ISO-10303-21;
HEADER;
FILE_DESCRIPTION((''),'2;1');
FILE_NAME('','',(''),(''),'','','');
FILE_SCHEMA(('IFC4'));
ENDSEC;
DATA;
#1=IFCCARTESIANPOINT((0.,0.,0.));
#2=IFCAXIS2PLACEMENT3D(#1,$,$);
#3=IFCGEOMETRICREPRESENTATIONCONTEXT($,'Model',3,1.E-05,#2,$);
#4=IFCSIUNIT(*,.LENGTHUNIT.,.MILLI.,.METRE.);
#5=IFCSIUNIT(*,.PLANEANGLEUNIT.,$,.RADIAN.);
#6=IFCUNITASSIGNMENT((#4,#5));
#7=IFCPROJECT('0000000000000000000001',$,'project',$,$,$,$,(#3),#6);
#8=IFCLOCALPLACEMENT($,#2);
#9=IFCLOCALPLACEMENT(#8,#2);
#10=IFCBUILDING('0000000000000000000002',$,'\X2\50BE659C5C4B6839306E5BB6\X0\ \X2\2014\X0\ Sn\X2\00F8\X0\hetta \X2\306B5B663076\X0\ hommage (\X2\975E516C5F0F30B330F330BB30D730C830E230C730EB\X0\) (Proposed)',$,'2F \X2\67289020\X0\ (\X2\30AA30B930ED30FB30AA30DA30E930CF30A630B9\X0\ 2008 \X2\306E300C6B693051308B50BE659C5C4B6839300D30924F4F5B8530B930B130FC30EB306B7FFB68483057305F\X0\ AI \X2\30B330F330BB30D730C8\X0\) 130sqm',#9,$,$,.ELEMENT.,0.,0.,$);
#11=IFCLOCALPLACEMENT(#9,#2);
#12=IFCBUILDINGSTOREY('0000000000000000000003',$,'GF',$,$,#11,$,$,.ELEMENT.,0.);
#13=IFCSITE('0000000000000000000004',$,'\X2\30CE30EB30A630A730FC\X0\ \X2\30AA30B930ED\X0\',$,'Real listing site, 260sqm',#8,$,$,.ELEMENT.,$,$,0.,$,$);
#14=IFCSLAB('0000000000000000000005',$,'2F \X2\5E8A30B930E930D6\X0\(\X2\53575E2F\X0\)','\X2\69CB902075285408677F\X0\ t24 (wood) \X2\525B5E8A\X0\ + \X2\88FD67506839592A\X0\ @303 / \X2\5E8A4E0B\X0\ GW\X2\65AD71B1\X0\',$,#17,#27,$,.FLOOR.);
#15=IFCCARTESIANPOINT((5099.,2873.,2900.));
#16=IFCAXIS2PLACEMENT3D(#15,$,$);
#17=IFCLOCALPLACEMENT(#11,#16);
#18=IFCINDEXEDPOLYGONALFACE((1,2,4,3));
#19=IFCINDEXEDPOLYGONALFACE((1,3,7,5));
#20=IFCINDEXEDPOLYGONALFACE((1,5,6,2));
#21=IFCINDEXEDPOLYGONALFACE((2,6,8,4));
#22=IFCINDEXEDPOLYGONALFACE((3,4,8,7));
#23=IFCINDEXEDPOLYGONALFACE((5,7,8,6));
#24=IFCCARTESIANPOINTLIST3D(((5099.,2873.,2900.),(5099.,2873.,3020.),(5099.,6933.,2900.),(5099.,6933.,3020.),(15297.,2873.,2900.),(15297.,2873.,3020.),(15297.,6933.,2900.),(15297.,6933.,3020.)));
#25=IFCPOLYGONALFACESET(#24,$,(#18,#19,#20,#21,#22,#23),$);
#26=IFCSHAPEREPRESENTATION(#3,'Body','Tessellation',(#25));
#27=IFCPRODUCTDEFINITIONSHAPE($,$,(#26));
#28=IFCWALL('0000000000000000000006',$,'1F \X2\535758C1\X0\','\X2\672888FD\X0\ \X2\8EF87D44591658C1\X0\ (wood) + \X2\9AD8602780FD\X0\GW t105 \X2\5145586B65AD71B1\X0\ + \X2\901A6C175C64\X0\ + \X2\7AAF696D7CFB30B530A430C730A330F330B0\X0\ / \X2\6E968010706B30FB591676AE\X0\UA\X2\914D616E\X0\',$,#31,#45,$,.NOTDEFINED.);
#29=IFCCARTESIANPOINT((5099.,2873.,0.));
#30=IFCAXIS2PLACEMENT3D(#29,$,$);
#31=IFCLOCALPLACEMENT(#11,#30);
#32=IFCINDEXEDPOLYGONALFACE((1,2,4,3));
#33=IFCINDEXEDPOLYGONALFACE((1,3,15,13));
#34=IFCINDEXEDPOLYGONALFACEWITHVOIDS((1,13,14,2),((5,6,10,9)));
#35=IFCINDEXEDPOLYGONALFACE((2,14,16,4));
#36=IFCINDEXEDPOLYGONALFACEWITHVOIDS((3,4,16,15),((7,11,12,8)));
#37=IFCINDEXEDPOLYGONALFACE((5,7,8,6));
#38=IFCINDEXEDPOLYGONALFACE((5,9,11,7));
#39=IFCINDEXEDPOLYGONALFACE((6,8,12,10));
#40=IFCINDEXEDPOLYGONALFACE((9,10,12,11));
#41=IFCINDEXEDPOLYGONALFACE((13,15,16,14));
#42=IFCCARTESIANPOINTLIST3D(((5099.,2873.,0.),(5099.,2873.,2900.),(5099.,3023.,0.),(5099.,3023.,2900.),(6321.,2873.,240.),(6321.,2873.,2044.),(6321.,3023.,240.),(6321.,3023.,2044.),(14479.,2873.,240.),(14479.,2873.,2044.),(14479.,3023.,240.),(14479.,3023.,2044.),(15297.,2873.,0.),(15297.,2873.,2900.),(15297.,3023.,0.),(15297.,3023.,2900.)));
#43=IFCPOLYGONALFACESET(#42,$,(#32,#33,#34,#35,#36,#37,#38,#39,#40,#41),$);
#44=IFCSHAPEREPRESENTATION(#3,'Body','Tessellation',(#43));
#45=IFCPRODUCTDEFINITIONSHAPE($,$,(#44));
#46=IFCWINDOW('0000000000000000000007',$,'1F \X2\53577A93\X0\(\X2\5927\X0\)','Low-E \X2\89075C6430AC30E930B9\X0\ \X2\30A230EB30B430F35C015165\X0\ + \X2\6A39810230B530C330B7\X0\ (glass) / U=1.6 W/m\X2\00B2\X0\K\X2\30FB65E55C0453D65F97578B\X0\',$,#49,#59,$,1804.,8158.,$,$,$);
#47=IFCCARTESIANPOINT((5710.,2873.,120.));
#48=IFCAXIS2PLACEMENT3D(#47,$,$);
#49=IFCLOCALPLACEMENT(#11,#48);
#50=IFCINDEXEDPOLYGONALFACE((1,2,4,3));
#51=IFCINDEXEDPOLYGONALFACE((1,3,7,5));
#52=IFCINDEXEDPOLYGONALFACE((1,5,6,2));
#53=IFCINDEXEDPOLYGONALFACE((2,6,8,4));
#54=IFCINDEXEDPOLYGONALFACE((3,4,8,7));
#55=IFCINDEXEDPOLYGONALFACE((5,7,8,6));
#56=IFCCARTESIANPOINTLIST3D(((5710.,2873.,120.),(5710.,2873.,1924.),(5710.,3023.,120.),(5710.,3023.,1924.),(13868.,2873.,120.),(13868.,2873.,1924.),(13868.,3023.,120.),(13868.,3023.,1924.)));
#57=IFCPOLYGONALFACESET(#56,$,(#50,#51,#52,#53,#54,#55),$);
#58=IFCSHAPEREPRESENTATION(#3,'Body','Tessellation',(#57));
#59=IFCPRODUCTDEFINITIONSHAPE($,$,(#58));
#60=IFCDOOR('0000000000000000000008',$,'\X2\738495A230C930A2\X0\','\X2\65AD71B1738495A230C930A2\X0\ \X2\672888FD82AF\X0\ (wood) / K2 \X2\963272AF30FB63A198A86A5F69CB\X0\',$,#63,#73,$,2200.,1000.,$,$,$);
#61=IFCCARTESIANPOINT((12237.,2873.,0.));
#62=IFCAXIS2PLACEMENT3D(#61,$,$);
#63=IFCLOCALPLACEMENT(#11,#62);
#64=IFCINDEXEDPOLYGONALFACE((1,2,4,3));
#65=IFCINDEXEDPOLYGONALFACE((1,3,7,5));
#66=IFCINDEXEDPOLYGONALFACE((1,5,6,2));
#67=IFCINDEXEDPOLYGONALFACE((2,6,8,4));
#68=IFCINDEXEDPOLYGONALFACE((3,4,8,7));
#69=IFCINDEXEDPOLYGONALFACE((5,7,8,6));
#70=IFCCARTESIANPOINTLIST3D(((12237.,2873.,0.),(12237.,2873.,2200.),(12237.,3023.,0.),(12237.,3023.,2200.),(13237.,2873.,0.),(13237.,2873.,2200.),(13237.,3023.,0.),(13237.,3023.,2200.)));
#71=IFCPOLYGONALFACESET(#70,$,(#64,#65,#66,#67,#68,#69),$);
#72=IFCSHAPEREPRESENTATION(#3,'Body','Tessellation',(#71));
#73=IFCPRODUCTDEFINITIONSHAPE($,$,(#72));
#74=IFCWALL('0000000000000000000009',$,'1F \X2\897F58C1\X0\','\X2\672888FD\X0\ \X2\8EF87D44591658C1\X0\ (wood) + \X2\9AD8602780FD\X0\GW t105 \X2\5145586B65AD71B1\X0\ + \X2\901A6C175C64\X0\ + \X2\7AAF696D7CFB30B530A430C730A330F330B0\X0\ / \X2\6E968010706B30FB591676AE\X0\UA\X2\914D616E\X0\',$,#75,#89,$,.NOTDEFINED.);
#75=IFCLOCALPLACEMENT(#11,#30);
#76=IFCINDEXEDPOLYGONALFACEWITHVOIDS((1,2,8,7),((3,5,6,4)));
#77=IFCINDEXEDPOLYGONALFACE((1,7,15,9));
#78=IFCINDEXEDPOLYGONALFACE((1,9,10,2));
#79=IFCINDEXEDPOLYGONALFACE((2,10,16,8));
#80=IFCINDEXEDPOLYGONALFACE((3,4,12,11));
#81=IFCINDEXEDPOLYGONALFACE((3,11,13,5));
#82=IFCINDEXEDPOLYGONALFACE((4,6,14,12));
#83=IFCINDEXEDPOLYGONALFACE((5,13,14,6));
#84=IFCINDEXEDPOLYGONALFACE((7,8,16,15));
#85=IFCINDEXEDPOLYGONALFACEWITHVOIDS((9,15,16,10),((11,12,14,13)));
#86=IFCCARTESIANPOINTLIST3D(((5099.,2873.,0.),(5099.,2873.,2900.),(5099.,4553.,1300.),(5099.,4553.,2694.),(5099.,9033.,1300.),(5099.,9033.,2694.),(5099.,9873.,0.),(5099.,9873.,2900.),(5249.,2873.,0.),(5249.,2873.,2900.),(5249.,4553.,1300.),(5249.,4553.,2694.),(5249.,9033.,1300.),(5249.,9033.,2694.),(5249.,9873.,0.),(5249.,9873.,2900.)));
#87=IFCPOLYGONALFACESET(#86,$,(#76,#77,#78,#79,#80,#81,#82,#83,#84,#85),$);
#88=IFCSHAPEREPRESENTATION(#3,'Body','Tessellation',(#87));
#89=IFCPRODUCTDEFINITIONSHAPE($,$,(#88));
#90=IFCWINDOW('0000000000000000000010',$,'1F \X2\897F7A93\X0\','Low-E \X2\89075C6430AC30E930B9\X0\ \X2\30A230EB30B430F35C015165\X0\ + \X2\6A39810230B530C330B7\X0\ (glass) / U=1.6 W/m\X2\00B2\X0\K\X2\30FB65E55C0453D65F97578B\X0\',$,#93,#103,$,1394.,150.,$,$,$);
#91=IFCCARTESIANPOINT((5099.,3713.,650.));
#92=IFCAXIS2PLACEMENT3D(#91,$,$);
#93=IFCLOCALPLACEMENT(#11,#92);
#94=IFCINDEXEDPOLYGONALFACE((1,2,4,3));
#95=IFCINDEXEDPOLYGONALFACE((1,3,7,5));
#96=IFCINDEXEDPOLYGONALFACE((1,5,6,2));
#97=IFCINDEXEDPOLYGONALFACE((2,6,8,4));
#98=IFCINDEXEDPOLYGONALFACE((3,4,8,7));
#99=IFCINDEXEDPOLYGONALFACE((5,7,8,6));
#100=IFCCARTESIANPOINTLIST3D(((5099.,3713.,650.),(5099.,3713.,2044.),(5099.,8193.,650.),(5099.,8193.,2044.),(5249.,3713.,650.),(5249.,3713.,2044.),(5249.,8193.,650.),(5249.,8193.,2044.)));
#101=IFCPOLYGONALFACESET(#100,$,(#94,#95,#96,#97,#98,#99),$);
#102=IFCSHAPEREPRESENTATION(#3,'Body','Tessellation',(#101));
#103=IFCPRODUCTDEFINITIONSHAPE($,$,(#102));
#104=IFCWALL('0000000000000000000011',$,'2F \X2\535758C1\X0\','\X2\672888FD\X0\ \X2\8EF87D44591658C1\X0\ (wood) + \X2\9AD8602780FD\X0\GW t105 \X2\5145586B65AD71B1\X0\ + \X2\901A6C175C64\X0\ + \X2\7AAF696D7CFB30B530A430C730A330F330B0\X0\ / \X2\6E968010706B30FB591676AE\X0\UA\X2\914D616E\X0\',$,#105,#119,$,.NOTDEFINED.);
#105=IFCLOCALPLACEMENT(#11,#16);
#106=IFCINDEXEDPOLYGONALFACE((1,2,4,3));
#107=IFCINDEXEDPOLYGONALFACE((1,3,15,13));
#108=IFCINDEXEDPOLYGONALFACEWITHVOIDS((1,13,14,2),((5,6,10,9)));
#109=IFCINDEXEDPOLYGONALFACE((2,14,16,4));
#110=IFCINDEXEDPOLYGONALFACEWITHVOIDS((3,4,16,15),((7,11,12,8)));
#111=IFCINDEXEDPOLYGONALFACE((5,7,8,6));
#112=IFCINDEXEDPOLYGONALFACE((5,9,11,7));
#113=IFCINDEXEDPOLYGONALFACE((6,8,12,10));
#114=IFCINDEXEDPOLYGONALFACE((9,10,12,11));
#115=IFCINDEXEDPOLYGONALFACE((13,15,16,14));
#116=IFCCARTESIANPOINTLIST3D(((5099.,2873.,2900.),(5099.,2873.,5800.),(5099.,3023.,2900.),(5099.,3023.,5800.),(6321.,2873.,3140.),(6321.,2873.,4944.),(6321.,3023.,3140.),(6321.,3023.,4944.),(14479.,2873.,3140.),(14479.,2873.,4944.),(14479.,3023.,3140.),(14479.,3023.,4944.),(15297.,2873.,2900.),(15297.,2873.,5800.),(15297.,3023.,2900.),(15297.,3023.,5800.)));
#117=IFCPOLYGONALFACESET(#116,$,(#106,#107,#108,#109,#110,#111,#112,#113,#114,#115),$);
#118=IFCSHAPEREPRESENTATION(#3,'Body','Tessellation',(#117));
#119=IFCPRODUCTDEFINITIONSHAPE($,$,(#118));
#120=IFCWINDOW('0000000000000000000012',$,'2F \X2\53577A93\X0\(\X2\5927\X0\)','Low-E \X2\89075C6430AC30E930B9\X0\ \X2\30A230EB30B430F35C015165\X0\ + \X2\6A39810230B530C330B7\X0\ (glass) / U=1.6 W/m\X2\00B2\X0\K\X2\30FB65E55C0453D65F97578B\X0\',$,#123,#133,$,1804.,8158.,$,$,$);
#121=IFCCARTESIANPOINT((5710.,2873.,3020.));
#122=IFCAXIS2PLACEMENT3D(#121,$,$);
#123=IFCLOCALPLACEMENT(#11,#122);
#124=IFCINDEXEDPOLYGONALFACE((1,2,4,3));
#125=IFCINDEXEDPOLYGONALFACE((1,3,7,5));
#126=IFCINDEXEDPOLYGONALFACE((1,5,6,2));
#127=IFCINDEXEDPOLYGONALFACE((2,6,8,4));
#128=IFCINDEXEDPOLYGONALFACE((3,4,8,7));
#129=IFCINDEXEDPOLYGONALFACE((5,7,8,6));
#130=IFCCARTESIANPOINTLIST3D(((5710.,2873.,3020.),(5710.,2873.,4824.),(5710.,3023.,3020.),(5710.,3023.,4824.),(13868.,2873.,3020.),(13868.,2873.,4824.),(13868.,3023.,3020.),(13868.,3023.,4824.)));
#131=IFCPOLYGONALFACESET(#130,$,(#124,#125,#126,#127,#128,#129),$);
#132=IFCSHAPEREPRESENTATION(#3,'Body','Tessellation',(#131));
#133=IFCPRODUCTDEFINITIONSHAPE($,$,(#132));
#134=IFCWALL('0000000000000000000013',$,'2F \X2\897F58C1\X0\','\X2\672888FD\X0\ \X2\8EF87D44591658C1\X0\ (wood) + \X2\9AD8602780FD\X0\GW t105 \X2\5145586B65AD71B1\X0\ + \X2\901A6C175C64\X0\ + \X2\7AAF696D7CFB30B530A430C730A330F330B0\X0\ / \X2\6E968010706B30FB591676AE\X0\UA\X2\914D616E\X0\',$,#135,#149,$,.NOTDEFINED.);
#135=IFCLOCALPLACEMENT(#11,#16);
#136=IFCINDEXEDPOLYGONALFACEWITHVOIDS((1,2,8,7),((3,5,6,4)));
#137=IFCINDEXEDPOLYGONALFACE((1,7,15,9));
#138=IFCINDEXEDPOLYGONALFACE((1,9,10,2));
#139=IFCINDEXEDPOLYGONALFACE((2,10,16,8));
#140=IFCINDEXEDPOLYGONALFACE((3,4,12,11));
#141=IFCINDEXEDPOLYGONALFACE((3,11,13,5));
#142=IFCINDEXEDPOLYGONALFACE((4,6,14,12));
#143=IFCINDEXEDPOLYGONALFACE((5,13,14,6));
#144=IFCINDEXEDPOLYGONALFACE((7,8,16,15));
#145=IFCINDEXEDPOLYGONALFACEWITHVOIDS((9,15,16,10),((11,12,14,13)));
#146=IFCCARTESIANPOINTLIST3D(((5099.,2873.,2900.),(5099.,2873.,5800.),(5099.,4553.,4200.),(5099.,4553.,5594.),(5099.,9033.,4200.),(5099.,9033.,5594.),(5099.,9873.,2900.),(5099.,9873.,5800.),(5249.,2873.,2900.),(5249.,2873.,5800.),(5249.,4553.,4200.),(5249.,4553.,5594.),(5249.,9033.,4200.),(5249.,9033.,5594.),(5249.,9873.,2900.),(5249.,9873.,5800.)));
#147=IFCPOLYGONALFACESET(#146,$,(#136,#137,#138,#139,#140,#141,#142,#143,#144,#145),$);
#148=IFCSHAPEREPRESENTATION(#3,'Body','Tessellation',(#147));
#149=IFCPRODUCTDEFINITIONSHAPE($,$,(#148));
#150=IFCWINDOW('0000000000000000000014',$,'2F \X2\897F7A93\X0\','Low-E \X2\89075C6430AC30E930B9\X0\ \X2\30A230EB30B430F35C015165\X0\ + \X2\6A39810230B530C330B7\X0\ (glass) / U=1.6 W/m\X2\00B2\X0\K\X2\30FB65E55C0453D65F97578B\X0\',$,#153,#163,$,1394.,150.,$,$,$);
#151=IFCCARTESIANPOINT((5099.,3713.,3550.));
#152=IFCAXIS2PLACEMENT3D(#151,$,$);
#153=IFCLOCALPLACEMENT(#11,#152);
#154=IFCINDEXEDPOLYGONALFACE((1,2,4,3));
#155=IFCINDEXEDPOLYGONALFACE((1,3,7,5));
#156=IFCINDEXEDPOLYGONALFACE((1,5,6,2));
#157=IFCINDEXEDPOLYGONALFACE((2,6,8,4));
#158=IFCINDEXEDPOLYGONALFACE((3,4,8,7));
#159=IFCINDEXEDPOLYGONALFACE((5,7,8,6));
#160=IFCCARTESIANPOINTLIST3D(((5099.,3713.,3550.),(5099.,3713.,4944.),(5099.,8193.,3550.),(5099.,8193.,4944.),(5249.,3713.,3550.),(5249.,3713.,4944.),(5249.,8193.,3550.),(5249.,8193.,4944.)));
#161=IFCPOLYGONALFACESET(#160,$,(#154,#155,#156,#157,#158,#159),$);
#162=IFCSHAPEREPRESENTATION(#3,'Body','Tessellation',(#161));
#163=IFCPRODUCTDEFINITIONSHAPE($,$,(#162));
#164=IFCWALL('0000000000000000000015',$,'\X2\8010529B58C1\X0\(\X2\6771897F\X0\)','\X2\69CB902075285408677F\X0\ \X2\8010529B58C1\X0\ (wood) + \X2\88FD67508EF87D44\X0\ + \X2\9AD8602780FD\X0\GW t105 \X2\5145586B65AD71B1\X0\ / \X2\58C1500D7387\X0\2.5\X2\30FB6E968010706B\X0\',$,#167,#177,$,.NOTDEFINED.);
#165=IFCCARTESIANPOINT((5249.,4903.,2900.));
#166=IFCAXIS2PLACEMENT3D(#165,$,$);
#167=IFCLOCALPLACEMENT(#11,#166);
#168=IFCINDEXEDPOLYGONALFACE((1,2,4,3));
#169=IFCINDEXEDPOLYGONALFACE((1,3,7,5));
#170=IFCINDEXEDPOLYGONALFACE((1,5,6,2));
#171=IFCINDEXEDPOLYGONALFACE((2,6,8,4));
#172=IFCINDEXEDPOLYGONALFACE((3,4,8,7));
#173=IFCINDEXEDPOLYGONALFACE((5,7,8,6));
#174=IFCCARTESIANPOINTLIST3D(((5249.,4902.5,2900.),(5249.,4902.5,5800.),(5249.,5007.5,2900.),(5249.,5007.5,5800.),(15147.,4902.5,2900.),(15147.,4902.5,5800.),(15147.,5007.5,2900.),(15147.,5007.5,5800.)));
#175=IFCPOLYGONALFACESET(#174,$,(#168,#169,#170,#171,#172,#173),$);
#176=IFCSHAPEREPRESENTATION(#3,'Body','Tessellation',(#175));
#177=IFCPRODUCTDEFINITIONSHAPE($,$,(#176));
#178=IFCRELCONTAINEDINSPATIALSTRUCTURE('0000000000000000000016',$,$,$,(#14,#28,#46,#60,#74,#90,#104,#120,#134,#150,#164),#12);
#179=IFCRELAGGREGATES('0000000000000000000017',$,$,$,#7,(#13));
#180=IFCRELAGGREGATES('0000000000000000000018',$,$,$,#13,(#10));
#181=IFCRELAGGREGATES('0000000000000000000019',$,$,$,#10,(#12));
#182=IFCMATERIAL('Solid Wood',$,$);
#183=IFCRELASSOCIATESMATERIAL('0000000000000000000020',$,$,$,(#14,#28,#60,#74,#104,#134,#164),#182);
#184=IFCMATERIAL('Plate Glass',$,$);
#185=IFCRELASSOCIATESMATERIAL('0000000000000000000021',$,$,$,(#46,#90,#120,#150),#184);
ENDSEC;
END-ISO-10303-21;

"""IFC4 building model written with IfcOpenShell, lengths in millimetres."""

from ifc_helpers import new_model, si_unit, frame, frame_2d, origin, place, context, project, spatial, rectangle, extrude, material, element, fill, save


model = new_model("IFC4")

# Units and contexts
model_context = context("Model", 3, precision=1e-05, world=origin())
ifc_project = project(units=[si_unit("LENGTHUNIT", "METRE", prefix="MILLI"), si_unit("PLANEANGLEUNIT", "RADIAN")], contexts=[model_context])

# Site, building, storey
site_placement = place(None, origin())
site = spatial("IfcSite", under=ifc_project, at=site_placement, Name="ノルウェー オスロ", ObjectType="Real listing site, 260sqm", CompositionType="ELEMENT", RefElevation=0.0)
building_placement = place(site_placement, origin())
building = spatial("IfcBuilding", under=site, at=building_placement, Name="傾斜屋根の家 — Snøhetta に学ぶ hommage (非公式コンセプトモデル) (Proposed)", ObjectType="2F 木造 (オスロ・オペラハウス 2008 の「歩ける傾斜屋根」を住宅スケールに翻案した AI コンセプト) 130sqm", CompositionType="ELEMENT", ElevationOfRefHeight=0.0, ElevationOfTerrain=0.0)
storey_placement = place(building_placement, origin())
storey = spatial("IfcBuildingStorey", under=building, at=storey_placement, Name="GF", CompositionType="ELEMENT", Elevation=0.0)

# Slab
ifc_material_1 = material(Name="Solid Wood")
slab_1_placement = place(storey_placement, frame((5099.0, 2873.0, 2900.0)))
element("IfcSlab", 1, at=slab_1_placement, inside=storey, material=ifc_material_1, Name="2F 床スラブ(南帯)", Description="構造用合板 t24 (wood) 剛床 + 製材根太 @303 / 床下 GW断熱", PredefinedType="FLOOR", context=model_context, shape_type="SweptSolid", body=[
    extrude(rectangle(XDim=10198.0, YDim=4060.0, at=frame_2d((5099.0, 2030.0))), frame((5099.0, 2873.0, 2900.0)), (0.0, 0.0, 1.0), 120.0),
])

# Wall, openings, window, door
wall_1_placement = place(storey_placement, frame((5099.0, 2873.0, 0.0)))
wall_1 = element("IfcWall", 2, at=wall_1_placement, inside=storey, material=ifc_material_1, Name="1F 南壁", Description="木製 軸組外壁 (wood) + 高性能GW t105 充填断熱 + 通気層 + 窯業系サイディング / 準耐火・外皮UA配慮", PredefinedType="NOTDEFINED", context=model_context, shape_type="SweptSolid", body=[
    extrude(rectangle(XDim=10198.0, YDim=150.0, at=frame_2d((5099.0, 75.0))), frame((5099.0, 2873.0, 0.0)), (0.0, 0.0, 1.0), 2900.0),
])
opening_1_placement = place(storey_placement, frame((5710.0, 2873.0, 120.0)))
opening_1 = element("IfcOpeningElement", 3, at=opening_1_placement, cuts=wall_1, PredefinedType="NOTDEFINED", context=model_context, shape_type="SweptSolid", body=[
    extrude(rectangle(XDim=8158.0, YDim=150.0, at=frame_2d((4079.0, 75.0))), frame((5710.0, 2873.0, 120.0)), (0.0, 0.0, 1.0), 1804.0),
])
opening_2_placement = place(storey_placement, frame((12237.0, 2873.0, 0.0)))
opening_2 = element("IfcOpeningElement", 4, at=opening_2_placement, cuts=wall_1, PredefinedType="NOTDEFINED", context=model_context, shape_type="SweptSolid", body=[
    extrude(rectangle(XDim=1000.0, YDim=150.0, at=frame_2d((500.0, 75.0))), frame((12237.0, 2873.0, 0.0)), (0.0, 0.0, 1.0), 2200.0),
])
ifc_material_2 = material(Name="Plate Glass")
window_1_placement = place(storey_placement, frame((5710.0, 2873.0, 120.0)))
window_1 = element("IfcWindow", 5, at=window_1_placement, inside=storey, material=ifc_material_2, Name="1F 南窓(大)", Description="Low-E 複層ガラス アルゴン封入 + 樹脂サッシ (glass) / U=1.6 W/m²K・日射取得型", OverallHeight=1804.0, OverallWidth=8158.0, context=model_context, shape_type="SweptSolid", body=[
    extrude(rectangle(XDim=8158.0, YDim=150.0, at=frame_2d((4079.0, 75.0))), frame((5710.0, 2873.0, 120.0)), (0.0, 0.0, 1.0), 1804.0),
])
fill(opening_1, window_1)
door_placement = place(storey_placement, frame((12237.0, 2873.0, 0.0)))
door = element("IfcDoor", 6, at=door_placement, inside=storey, material=ifc_material_1, Name="玄関ドア", Description="断熱玄関ドア 木製芯 (wood) / K2 防犯・採風機構", OverallHeight=2200.0, OverallWidth=1000.0, context=model_context, shape_type="SweptSolid", body=[
    extrude(rectangle(XDim=1000.0, YDim=150.0, at=frame_2d((500.0, 75.0))), frame((12237.0, 2873.0, 0.0)), (0.0, 0.0, 1.0), 2200.0),
])
fill(opening_2, door)

# Wall, opening, window
wall_2_placement = place(storey_placement, frame((5099.0, 2873.0, 0.0)))
wall_2 = element("IfcWall", 7, at=wall_2_placement, inside=storey, material=ifc_material_1, Name="1F 西壁", Description="木製 軸組外壁 (wood) + 高性能GW t105 充填断熱 + 通気層 + 窯業系サイディング / 準耐火・外皮UA配慮", PredefinedType="NOTDEFINED", context=model_context, shape_type="SweptSolid", body=[
    extrude(rectangle(XDim=150.0, YDim=7000.0, at=frame_2d((75.0, 3500.0))), frame((5099.0, 2873.0, 0.0)), (0.0, 0.0, 1.0), 2900.0),
])
opening_3_placement = place(storey_placement, frame((5099.0, 3713.0, 650.0)))
opening_3 = element("IfcOpeningElement", 8, at=opening_3_placement, cuts=wall_2, PredefinedType="NOTDEFINED", context=model_context, shape_type="SweptSolid", body=[
    extrude(rectangle(XDim=150.0, YDim=4480.0, at=frame_2d((75.0, 2240.0))), frame((5099.0, 3713.0, 650.0)), (0.0, 0.0, 1.0), 1394.0),
])
window_2_placement = place(storey_placement, frame((5099.0, 3713.0, 650.0)))
window_2 = element("IfcWindow", 9, at=window_2_placement, inside=storey, material=ifc_material_2, Name="1F 西窓", Description="Low-E 複層ガラス アルゴン封入 + 樹脂サッシ (glass) / U=1.6 W/m²K・日射取得型", OverallHeight=1394.0, OverallWidth=150.0, context=model_context, shape_type="SweptSolid", body=[
    extrude(rectangle(XDim=150.0, YDim=4480.0, at=frame_2d((75.0, 2240.0))), frame((5099.0, 3713.0, 650.0)), (0.0, 0.0, 1.0), 1394.0),
])
fill(opening_3, window_2)

# Walls, openings, windows
wall_3_placement = place(storey_placement, frame((5099.0, 2873.0, 2900.0)))
wall_3 = element("IfcWall", 10, at=wall_3_placement, inside=storey, material=ifc_material_1, Name="2F 南壁", Description="木製 軸組外壁 (wood) + 高性能GW t105 充填断熱 + 通気層 + 窯業系サイディング / 準耐火・外皮UA配慮", PredefinedType="NOTDEFINED", context=model_context, shape_type="SweptSolid", body=[
    extrude(rectangle(XDim=10198.0, YDim=150.0, at=frame_2d((5099.0, 75.0))), frame((5099.0, 2873.0, 2900.0)), (0.0, 0.0, 1.0), 2900.0),
])
opening_4_placement = place(storey_placement, frame((5710.0, 2873.0, 3020.0)))
opening_4 = element("IfcOpeningElement", 11, at=opening_4_placement, cuts=wall_3, PredefinedType="NOTDEFINED", context=model_context, shape_type="SweptSolid", body=[
    extrude(rectangle(XDim=8158.0, YDim=150.0, at=frame_2d((4079.0, 75.0))), frame((5710.0, 2873.0, 3020.0)), (0.0, 0.0, 1.0), 1804.0),
])
window_3_placement = place(storey_placement, frame((5710.0, 2873.0, 3020.0)))
window_3 = element("IfcWindow", 12, at=window_3_placement, inside=storey, material=ifc_material_2, Name="2F 南窓(大)", Description="Low-E 複層ガラス アルゴン封入 + 樹脂サッシ (glass) / U=1.6 W/m²K・日射取得型", OverallHeight=1804.0, OverallWidth=8158.0, context=model_context, shape_type="SweptSolid", body=[
    extrude(rectangle(XDim=8158.0, YDim=150.0, at=frame_2d((4079.0, 75.0))), frame((5710.0, 2873.0, 3020.0)), (0.0, 0.0, 1.0), 1804.0),
])
fill(opening_4, window_3)
wall_4_placement = place(storey_placement, frame((5099.0, 2873.0, 2900.0)))
wall_4 = element("IfcWall", 13, at=wall_4_placement, inside=storey, material=ifc_material_1, Name="2F 西壁", Description="木製 軸組外壁 (wood) + 高性能GW t105 充填断熱 + 通気層 + 窯業系サイディング / 準耐火・外皮UA配慮", PredefinedType="NOTDEFINED", context=model_context, shape_type="SweptSolid", body=[
    extrude(rectangle(XDim=150.0, YDim=7000.0, at=frame_2d((75.0, 3500.0))), frame((5099.0, 2873.0, 2900.0)), (0.0, 0.0, 1.0), 2900.0),
])
opening_5_placement = place(storey_placement, frame((5099.0, 3713.0, 3550.0)))
opening_5 = element("IfcOpeningElement", 14, at=opening_5_placement, cuts=wall_4, PredefinedType="NOTDEFINED", context=model_context, shape_type="SweptSolid", body=[
    extrude(rectangle(XDim=150.0, YDim=4480.0, at=frame_2d((75.0, 2240.0))), frame((5099.0, 3713.0, 3550.0)), (0.0, 0.0, 1.0), 1394.0),
])
window_4_placement = place(storey_placement, frame((5099.0, 3713.0, 3550.0)))
window_4 = element("IfcWindow", 15, at=window_4_placement, inside=storey, material=ifc_material_2, Name="2F 西窓", Description="Low-E 複層ガラス アルゴン封入 + 樹脂サッシ (glass) / U=1.6 W/m²K・日射取得型", OverallHeight=1394.0, OverallWidth=150.0, context=model_context, shape_type="SweptSolid", body=[
    extrude(rectangle(XDim=150.0, YDim=4480.0, at=frame_2d((75.0, 2240.0))), frame((5099.0, 3713.0, 3550.0)), (0.0, 0.0, 1.0), 1394.0),
])
fill(opening_5, window_4)

# Wall
wall_5_placement = place(storey_placement, frame((5249.0, 4903.0, 2900.0)))
element("IfcWall", 16, at=wall_5_placement, inside=storey, material=ifc_material_1, Name="耐力壁(東西)", Description="構造用合板 耐力壁 (wood) + 製材軸組 + 高性能GW t105 充填断熱 / 壁倍率2.5・準耐火", PredefinedType="NOTDEFINED", context=model_context, shape_type="SweptSolid", body=[
    extrude(rectangle(XDim=9898.0, YDim=105.0, at=frame_2d((4949.0, 52.0))), frame((5249.0, 4903.0, 2900.0)), (0.0, 0.0, 1.0), 2900.0),
])

save(model, "model.ifc")
